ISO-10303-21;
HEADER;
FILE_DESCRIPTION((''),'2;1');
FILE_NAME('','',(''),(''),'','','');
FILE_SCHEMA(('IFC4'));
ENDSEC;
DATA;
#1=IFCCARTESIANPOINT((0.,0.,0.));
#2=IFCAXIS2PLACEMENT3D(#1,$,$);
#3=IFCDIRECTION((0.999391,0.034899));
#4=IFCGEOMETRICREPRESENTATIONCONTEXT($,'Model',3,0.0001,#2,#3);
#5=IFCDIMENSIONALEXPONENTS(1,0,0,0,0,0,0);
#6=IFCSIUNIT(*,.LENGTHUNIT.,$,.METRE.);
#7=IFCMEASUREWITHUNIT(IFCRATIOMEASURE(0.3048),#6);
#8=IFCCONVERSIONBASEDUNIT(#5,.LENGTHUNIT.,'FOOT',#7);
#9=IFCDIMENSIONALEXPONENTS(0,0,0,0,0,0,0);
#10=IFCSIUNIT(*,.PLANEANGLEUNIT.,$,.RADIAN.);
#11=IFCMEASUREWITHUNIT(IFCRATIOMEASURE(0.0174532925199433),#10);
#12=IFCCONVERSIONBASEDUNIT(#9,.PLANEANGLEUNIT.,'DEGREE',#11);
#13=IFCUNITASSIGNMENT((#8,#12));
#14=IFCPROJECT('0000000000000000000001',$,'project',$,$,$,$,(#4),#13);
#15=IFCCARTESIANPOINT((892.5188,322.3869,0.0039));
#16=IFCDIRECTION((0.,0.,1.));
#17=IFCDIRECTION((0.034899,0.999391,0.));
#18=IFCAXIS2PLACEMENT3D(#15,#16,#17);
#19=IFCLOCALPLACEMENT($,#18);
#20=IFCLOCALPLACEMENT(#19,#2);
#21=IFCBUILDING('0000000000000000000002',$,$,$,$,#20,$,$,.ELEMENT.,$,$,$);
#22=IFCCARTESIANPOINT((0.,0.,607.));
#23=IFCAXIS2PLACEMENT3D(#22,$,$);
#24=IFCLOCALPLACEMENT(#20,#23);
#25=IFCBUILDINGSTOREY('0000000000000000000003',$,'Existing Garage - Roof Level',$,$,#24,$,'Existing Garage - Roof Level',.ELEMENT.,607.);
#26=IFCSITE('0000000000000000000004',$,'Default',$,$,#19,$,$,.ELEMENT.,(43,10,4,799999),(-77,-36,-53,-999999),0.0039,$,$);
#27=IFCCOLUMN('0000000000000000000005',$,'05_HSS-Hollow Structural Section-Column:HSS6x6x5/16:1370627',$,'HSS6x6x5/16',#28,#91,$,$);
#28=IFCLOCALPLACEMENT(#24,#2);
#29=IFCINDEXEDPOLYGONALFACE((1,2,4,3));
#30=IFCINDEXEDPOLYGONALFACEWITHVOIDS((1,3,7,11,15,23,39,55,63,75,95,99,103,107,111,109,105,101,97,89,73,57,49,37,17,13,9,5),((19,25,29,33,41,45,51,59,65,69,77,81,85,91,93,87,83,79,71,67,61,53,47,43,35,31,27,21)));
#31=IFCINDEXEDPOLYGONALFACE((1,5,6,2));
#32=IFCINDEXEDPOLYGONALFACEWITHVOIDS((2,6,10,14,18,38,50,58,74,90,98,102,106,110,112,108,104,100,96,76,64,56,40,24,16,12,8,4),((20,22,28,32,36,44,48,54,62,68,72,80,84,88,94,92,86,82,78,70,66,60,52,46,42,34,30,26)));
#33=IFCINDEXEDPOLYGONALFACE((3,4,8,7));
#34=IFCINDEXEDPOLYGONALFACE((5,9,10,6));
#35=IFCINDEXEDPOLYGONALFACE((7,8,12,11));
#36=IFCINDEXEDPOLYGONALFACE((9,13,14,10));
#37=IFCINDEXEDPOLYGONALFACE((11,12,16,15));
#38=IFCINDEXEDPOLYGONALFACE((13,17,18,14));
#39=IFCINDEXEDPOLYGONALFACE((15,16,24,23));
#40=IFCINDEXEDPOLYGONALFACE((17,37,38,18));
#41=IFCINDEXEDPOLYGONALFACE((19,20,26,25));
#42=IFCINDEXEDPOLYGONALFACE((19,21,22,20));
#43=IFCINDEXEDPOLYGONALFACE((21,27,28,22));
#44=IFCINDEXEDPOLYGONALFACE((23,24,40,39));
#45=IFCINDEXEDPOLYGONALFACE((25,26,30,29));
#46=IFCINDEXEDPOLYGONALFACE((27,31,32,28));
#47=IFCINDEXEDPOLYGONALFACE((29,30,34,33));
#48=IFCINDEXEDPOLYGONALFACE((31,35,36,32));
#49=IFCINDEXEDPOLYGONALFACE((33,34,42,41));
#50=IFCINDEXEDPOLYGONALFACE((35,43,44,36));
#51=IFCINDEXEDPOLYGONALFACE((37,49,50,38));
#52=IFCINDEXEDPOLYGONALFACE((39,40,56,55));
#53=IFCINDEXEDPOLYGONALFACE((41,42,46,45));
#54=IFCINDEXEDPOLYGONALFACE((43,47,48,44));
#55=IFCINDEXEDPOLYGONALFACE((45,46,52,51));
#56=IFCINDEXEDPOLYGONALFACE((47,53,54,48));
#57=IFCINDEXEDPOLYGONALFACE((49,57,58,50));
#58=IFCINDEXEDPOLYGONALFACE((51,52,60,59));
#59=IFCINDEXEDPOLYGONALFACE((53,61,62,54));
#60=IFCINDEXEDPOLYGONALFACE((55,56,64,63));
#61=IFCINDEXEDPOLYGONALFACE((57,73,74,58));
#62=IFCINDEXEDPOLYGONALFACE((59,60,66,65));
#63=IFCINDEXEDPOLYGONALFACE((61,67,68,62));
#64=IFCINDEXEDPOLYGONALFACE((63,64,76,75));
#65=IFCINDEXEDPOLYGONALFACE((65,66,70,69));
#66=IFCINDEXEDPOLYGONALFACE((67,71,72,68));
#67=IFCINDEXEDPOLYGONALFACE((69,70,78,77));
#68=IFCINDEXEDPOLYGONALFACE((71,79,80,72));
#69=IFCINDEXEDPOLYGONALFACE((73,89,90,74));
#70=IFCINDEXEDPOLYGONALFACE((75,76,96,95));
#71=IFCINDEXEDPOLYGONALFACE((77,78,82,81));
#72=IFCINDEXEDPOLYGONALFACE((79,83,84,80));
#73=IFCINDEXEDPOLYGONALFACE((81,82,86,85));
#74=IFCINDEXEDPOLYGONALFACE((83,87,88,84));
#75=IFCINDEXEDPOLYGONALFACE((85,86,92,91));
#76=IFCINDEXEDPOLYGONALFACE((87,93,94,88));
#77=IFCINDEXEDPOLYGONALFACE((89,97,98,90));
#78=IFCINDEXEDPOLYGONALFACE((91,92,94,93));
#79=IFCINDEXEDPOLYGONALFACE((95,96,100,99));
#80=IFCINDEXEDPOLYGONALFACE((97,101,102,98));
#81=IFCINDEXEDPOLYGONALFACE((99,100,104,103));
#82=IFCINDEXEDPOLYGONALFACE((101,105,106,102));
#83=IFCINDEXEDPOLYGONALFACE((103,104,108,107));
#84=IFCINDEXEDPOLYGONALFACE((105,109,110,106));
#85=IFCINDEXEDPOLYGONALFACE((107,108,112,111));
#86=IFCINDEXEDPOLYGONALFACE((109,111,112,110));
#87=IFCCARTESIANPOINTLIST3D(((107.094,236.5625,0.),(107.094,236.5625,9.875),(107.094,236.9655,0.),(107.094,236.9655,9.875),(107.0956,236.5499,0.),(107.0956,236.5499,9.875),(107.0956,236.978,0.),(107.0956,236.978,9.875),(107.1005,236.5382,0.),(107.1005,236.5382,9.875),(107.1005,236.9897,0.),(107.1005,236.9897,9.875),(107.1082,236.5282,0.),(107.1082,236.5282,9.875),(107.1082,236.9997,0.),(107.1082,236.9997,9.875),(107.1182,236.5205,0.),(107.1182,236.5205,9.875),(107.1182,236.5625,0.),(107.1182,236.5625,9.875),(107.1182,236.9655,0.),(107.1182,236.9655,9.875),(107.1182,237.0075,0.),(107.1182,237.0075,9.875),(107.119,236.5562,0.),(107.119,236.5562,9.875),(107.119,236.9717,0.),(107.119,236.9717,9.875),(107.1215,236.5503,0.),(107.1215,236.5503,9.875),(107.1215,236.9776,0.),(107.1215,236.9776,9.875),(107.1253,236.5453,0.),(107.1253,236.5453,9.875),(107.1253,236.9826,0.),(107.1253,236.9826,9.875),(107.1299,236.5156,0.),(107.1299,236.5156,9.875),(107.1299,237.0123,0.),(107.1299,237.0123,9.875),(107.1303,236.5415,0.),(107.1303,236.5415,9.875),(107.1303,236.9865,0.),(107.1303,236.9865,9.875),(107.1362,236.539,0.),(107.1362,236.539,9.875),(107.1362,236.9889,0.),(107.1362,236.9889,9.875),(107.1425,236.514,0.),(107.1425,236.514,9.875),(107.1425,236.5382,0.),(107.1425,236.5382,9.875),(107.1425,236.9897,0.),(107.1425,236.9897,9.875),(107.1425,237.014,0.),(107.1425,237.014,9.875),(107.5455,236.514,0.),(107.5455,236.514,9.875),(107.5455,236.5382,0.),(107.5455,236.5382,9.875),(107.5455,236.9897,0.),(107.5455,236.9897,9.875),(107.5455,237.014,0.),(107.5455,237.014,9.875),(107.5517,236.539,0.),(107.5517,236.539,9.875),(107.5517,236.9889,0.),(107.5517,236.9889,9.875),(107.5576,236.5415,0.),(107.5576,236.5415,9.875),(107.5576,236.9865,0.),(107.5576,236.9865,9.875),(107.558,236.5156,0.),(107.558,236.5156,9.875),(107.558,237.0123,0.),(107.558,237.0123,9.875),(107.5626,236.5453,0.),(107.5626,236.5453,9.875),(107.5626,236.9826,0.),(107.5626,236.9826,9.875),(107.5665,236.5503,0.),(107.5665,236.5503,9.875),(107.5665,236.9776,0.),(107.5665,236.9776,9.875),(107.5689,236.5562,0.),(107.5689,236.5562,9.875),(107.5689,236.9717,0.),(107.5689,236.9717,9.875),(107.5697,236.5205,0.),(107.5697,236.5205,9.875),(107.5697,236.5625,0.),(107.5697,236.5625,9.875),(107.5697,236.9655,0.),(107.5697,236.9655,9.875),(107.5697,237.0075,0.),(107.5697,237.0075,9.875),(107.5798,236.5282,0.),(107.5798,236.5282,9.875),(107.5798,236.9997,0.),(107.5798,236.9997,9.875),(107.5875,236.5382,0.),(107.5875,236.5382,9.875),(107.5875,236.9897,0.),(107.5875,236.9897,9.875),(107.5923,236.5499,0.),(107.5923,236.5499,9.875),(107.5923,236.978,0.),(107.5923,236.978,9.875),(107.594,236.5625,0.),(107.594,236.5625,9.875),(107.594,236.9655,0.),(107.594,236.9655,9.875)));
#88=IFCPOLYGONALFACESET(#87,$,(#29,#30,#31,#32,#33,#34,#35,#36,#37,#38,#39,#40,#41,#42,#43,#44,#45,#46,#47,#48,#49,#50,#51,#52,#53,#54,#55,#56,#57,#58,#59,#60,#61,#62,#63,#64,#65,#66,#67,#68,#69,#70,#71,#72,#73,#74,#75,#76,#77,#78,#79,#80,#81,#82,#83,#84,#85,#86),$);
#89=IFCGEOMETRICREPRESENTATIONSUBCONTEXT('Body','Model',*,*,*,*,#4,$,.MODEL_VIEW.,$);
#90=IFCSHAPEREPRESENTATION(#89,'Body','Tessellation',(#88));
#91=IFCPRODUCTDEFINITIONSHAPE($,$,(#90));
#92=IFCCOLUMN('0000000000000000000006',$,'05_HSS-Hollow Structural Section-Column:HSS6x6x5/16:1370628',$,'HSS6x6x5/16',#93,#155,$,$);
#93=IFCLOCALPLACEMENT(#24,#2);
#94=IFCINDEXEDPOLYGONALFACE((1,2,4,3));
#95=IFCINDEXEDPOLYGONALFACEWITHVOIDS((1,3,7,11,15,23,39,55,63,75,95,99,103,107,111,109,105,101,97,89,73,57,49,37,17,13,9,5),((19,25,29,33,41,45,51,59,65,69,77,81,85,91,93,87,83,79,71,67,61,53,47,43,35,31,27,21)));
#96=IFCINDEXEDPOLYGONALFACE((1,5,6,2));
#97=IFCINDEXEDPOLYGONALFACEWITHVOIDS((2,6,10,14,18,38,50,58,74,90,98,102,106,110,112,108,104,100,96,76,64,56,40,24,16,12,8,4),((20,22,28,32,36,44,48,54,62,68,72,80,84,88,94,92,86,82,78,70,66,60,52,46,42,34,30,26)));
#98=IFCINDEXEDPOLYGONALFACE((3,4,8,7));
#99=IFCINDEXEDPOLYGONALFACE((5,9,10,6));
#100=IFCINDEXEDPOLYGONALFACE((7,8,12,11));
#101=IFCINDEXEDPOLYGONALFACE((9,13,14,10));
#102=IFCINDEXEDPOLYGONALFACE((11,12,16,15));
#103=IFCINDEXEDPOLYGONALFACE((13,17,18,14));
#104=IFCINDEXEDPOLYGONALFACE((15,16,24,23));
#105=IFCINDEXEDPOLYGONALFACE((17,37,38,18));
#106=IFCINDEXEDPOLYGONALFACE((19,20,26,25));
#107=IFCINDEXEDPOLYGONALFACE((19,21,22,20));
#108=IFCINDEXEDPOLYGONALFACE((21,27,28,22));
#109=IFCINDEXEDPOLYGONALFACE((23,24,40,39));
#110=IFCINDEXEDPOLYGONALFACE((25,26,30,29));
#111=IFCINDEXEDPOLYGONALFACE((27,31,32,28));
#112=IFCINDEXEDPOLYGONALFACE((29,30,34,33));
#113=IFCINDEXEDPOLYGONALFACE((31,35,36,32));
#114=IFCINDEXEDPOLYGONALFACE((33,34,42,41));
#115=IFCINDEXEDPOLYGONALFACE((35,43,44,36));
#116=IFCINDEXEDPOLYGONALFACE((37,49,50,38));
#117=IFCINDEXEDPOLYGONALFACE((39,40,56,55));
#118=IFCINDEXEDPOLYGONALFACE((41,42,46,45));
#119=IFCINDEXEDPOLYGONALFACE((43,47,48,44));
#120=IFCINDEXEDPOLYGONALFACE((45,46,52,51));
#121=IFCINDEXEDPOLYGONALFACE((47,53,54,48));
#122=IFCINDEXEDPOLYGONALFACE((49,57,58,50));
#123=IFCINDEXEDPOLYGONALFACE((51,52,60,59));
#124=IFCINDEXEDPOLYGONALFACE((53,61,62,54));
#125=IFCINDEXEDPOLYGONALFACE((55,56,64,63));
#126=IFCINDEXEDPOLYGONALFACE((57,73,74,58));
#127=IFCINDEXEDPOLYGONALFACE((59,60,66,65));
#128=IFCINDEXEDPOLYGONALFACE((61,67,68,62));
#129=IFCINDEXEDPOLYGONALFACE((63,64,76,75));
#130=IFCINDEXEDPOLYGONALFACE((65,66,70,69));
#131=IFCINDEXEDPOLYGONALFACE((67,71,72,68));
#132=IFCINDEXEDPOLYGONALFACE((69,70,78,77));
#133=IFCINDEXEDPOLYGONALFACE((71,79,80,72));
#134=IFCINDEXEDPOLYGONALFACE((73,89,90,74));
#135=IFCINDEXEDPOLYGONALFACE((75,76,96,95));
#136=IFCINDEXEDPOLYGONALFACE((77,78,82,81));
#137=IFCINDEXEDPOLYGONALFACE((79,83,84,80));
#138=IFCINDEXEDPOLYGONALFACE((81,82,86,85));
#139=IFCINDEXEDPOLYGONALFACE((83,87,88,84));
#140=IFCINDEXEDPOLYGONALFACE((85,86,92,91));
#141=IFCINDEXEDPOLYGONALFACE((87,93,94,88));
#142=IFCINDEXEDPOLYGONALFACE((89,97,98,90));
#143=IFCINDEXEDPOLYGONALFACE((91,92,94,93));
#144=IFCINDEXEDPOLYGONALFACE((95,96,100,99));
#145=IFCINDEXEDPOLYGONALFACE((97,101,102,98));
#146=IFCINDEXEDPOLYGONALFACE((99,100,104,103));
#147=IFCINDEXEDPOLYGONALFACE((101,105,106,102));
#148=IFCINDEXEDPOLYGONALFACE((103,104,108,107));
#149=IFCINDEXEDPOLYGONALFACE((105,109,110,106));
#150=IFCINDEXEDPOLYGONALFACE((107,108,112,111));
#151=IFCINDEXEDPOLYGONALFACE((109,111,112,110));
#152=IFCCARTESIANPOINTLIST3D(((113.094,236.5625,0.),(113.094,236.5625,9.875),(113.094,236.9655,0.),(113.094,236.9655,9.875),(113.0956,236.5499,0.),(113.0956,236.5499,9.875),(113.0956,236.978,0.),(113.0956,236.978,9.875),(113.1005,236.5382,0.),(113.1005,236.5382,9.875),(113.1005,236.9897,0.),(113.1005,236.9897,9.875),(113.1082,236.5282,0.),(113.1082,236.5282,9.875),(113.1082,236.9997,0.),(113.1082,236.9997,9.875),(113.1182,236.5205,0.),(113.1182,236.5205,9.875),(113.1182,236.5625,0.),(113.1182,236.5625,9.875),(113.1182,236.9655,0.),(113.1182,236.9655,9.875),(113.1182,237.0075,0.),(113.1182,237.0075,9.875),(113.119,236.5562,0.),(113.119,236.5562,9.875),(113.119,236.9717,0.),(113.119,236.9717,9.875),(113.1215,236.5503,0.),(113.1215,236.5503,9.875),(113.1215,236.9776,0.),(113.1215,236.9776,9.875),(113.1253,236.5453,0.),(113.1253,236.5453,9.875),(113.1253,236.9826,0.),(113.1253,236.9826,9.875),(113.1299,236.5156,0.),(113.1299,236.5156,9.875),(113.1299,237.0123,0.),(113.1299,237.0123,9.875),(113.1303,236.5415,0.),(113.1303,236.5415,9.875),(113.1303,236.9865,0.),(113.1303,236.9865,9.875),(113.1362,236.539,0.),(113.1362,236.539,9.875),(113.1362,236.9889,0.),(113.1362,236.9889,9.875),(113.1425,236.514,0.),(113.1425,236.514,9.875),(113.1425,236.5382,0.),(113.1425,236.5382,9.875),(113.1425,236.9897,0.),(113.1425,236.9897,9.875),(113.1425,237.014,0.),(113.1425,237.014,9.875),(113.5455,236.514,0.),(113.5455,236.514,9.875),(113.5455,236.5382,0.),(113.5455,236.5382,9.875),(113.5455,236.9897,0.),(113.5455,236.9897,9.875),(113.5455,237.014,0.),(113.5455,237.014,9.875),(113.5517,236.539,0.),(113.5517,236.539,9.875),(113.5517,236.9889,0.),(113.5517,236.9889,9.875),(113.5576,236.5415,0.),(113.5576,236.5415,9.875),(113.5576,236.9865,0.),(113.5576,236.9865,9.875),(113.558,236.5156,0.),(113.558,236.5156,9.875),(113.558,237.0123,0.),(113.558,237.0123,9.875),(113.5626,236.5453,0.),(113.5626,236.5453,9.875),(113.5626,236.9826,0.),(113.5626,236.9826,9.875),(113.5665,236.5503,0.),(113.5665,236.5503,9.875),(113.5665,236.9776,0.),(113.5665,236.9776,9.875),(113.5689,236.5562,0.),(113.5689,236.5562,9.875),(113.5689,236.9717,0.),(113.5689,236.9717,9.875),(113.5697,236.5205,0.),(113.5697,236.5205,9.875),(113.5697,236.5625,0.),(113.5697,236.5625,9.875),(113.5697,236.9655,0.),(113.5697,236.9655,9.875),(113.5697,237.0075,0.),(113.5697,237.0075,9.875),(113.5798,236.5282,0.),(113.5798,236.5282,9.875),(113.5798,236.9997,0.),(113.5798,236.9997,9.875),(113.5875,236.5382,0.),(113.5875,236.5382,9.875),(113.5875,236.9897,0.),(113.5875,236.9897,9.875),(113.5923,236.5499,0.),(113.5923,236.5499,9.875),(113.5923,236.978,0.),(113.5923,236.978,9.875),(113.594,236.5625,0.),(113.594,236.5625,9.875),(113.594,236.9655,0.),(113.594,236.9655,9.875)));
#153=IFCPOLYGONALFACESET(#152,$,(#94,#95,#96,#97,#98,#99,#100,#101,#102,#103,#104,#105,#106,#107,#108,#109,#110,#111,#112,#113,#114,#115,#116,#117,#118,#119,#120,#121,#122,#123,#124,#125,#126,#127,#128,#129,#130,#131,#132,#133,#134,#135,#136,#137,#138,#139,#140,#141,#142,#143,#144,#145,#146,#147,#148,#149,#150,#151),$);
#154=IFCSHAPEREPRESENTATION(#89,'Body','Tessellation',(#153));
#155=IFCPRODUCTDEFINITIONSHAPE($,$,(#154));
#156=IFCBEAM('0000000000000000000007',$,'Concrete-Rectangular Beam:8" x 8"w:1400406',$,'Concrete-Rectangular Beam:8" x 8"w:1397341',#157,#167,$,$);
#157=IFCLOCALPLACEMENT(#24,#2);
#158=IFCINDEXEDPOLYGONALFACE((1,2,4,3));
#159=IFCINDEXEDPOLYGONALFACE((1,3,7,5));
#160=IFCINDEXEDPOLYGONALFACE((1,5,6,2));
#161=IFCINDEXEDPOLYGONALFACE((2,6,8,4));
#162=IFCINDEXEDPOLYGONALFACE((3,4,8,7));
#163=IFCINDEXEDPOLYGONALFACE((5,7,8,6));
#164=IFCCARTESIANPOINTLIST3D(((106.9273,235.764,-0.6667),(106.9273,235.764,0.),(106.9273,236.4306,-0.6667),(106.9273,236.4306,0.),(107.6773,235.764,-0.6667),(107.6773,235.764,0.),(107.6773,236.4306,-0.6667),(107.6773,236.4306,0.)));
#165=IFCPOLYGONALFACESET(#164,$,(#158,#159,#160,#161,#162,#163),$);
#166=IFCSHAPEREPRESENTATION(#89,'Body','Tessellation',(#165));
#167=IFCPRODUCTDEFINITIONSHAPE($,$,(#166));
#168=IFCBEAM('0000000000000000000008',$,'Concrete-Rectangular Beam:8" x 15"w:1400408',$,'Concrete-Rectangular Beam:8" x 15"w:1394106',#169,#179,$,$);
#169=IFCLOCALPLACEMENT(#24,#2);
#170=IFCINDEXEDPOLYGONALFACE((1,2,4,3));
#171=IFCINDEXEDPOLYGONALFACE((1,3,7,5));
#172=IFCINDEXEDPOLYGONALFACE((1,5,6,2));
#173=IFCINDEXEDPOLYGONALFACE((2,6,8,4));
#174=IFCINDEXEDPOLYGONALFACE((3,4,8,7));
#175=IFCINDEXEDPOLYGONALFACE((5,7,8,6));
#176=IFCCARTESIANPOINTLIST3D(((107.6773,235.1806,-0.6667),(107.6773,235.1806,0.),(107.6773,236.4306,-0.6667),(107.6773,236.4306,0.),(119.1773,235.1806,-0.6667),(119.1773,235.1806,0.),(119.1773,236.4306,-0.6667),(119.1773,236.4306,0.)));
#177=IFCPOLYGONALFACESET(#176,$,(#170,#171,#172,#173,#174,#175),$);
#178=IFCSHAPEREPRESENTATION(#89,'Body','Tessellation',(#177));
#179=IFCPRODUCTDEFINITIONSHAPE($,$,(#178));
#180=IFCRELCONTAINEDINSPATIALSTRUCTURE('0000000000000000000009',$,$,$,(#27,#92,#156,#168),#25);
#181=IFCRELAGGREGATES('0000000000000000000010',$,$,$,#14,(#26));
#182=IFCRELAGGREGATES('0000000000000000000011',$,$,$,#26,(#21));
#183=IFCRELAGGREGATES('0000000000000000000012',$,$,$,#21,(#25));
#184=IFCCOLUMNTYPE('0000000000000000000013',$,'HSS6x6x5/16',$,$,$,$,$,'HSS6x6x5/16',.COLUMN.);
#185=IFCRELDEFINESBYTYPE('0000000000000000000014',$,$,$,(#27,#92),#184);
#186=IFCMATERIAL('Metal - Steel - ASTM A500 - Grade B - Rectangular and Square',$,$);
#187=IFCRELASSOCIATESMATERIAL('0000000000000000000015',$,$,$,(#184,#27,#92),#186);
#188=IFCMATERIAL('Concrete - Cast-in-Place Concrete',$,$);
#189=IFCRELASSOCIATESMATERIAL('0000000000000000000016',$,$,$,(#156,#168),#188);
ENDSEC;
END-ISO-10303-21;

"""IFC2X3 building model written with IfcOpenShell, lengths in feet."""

from ifc_helpers import new_model, entity, si_unit, converted_unit, direction, frame, frame_2d, origin, origin_2d_with_axis, place, context, subcontext, project, spatial, polyline, circle_curve, parameter, trimmed, segment, composite_curve, rectangle, outline, extrude, source, transform, mapped, material, type_object, type_shapes, element, save


model = new_model("IFC2X3")

# Units and contexts
model_context = context("Model", 3, precision=0.0001, world=origin(), true_north=direction((0.999391, 0.034899)))
body_context = subcontext(model_context, "Body", "Model", "MODEL_VIEW")
ifc_project = project(units=[converted_unit("LENGTHUNIT", "FOOT", entity("IfcRatioMeasure", 0.3048), si_unit("LENGTHUNIT", "METRE"), dimensions=[1, 0, 0, 0, 0, 0, 0]), converted_unit("PLANEANGLEUNIT", "DEGREE", entity("IfcRatioMeasure", 0.0174532925199433), si_unit("PLANEANGLEUNIT", "RADIAN"), dimensions=[0, 0, 0, 0, 0, 0, 0])], contexts=[model_context])

# Site, building, storey
site_placement = place(None, frame((892.5188, 322.3869, 0.0039), z_axis=(0.0, 0.0, 1.0), x_axis=(0.034899, 0.999391, 0.0)))
site = spatial("IfcSite", under=ifc_project, at=site_placement, Name="Default", CompositionType="ELEMENT", RefLatitude=(43, 10, 4, 799999), RefLongitude=(-77, -36, -53, -999999), RefElevation=0.0039)
building_placement = place(site_placement, origin())
building = spatial("IfcBuilding", under=site, at=building_placement, CompositionType="ELEMENT")
storey_placement = place(building_placement, frame((0.0, 0.0, 607.0)))
storey = spatial("IfcBuildingStorey", under=building, at=storey_placement, Name="Existing Garage - Roof Level", LongName="Existing Garage - Roof Level", CompositionType="ELEMENT", Elevation=607.0)

# Columns
ifc_material_1 = material(Name="Metal - Steel - ASTM A500 - Grade B - Rectangular and Square")
column_type = type_object("IfcColumnType", Name="HSS6x6x5/16", ElementType="HSS6x6x5/16", PredefinedType="COLUMN", material=ifc_material_1)
shared_shape = source(origin(), body_context, "Body", "SweptSolid", [
    extrude(outline(composite_curve([segment(polyline([(-0.2015, -0.25), (0.2015, -0.25)]), True, "CONTINUOUS"), segment(trimmed(circle_curve(frame_2d((0.2015, -0.2015), x_axis=(-1.0, 0.0)), 0.0485), [parameter(90.0)], [parameter(180.0)], True, "PARAMETER"), True, "CONTINUOUS"), segment(polyline([(0.25, -0.2015), (0.25, 0.2015)]), True, "CONTINUOUS"), segment(trimmed(circle_curve(frame_2d((0.2015, 0.2015), x_axis=(-1.0, 0.0)), 0.0485), [parameter(180.0)], [parameter(270.0)], True, "PARAMETER"), True, "CONTINUOUS"), segment(polyline([(0.2015, 0.25), (-0.2015, 0.25)]), True, "CONTINUOUS"), segment(trimmed(circle_curve(frame_2d((-0.2015, 0.2015), x_axis=(-1.0, 0.0)), 0.0485), [parameter(270.0)], [parameter(360.0)], True, "PARAMETER"), True, "CONTINUOUS"), segment(polyline([(-0.25, 0.2015), (-0.25, -0.2015)]), True, "CONTINUOUS"), segment(trimmed(circle_curve(frame_2d((-0.2015, -0.2015), x_axis=(-1.0, 0.0)), 0.0485), [parameter(360.0)], [parameter(90.0)], True, "PARAMETER"), True, "CONTINUOUS")], self_intersect=False), holes=[composite_curve([segment(trimmed(circle_curve(frame_2d((-0.2015, -0.2015), x_axis=(-1.0, 0.0)), 0.0242), [parameter(0.0)], [parameter(90.0)], True, "PARAMETER"), False, "CONTINUOUS"), segment(polyline([(-0.2257, -0.2015), (-0.2257, 0.2015)]), True, "CONTINUOUS"), segment(trimmed(circle_curve(frame_2d((-0.2015, 0.2015), x_axis=(-1.0, 0.0)), 0.0242), [parameter(270.0)], [parameter(360.0)], True, "PARAMETER"), False, "CONTINUOUS"), segment(polyline([(-0.2015, 0.2258), (0.2015, 0.2258)]), True, "CONTINUOUS"), segment(trimmed(circle_curve(frame_2d((0.2015, 0.2015), x_axis=(-1.0, 0.0)), 0.0243), [parameter(180.0)], [parameter(270.0)], True, "PARAMETER"), False, "CONTINUOUS"), segment(polyline([(0.2258, 0.2015), (0.2258, -0.2015)]), True, "CONTINUOUS"), segment(trimmed(circle_curve(frame_2d((0.2015, -0.2015), x_axis=(-1.0, 0.0)), 0.0243), [parameter(90.0)], [parameter(180.0)], True, "PARAMETER"), False, "CONTINUOUS"), segment(polyline([(0.2015, -0.2257), (-0.2015, -0.2257)]), True, "CONTINUOUS")], self_intersect=False)]), frame((0.0, 0.0, 607.0), z_axis=(0.0, 0.0, 1.0), x_axis=(-1.0, 0.0, 0.0)), (0.0, 0.0, 1.0), 9.875),
])
type_shapes(column_type, [shared_shape])
for number, where, name in (
    (1, (107.344, 236.764, -607.0), "05_HSS-Hollow Structural Section-Column:HSS6x6x5/16:1370627"),
    (2, (113.344, 236.764, -607.0), "05_HSS-Hollow Structural Section-Column:HSS6x6x5/16:1370628"),
):
    element("IfcColumn", number, at=place(storey_placement, frame(where)), inside=storey, type_object=column_type, material=ifc_material_1, Name=name, ObjectType="HSS6x6x5/16", context=body_context, shape_type="MappedRepresentation", body=[
        mapped(shared_shape, transform((0.0, 0.0, 0.0), scale=1.0)),
    ])

# Beams
ifc_material_2 = material(Name="Concrete - Cast-in-Place Concrete")
beam_1_placement = place(storey_placement, frame((105.9273, 236.0973, 0.0)))
element("IfcBeam", 3, at=beam_1_placement, inside=storey, material=ifc_material_2, Name="Concrete-Rectangular Beam:8\" x 8\"w:1400406", ObjectType="Concrete-Rectangular Beam:8\" x 8\"w:1397341", context=body_context, shape_type="SweptSolid", body=[
    extrude(rectangle(XDim=0.6667, YDim=0.6667, at=origin_2d_with_axis()), frame((1.0, 0.0, -0.3333), z_axis=(1.0, 0.0, 0.0), x_axis=(0.0, 0.0, -1.0)), (0.0, 0.0, 1.0), 0.75),
])
beam_2_placement = place(storey_placement, frame((107.6773, 235.8056, 0.0)))
element("IfcBeam", 4, at=beam_2_placement, inside=storey, material=ifc_material_2, Name="Concrete-Rectangular Beam:8\" x 15\"w:1400408", ObjectType="Concrete-Rectangular Beam:8\" x 15\"w:1394106", context=body_context, shape_type="SweptSolid", body=[
    extrude(rectangle(XDim=0.6667, YDim=1.25, at=frame_2d((0.0, 0.0), x_axis=(1.0, 0.0))), frame((0.0, 0.0, -0.3333), z_axis=(1.0, 0.0, 0.0), x_axis=(0.0, 0.0, -1.0)), (0.0, 0.0, 1.0), 11.5),
])

save(model, "model.ifc")
